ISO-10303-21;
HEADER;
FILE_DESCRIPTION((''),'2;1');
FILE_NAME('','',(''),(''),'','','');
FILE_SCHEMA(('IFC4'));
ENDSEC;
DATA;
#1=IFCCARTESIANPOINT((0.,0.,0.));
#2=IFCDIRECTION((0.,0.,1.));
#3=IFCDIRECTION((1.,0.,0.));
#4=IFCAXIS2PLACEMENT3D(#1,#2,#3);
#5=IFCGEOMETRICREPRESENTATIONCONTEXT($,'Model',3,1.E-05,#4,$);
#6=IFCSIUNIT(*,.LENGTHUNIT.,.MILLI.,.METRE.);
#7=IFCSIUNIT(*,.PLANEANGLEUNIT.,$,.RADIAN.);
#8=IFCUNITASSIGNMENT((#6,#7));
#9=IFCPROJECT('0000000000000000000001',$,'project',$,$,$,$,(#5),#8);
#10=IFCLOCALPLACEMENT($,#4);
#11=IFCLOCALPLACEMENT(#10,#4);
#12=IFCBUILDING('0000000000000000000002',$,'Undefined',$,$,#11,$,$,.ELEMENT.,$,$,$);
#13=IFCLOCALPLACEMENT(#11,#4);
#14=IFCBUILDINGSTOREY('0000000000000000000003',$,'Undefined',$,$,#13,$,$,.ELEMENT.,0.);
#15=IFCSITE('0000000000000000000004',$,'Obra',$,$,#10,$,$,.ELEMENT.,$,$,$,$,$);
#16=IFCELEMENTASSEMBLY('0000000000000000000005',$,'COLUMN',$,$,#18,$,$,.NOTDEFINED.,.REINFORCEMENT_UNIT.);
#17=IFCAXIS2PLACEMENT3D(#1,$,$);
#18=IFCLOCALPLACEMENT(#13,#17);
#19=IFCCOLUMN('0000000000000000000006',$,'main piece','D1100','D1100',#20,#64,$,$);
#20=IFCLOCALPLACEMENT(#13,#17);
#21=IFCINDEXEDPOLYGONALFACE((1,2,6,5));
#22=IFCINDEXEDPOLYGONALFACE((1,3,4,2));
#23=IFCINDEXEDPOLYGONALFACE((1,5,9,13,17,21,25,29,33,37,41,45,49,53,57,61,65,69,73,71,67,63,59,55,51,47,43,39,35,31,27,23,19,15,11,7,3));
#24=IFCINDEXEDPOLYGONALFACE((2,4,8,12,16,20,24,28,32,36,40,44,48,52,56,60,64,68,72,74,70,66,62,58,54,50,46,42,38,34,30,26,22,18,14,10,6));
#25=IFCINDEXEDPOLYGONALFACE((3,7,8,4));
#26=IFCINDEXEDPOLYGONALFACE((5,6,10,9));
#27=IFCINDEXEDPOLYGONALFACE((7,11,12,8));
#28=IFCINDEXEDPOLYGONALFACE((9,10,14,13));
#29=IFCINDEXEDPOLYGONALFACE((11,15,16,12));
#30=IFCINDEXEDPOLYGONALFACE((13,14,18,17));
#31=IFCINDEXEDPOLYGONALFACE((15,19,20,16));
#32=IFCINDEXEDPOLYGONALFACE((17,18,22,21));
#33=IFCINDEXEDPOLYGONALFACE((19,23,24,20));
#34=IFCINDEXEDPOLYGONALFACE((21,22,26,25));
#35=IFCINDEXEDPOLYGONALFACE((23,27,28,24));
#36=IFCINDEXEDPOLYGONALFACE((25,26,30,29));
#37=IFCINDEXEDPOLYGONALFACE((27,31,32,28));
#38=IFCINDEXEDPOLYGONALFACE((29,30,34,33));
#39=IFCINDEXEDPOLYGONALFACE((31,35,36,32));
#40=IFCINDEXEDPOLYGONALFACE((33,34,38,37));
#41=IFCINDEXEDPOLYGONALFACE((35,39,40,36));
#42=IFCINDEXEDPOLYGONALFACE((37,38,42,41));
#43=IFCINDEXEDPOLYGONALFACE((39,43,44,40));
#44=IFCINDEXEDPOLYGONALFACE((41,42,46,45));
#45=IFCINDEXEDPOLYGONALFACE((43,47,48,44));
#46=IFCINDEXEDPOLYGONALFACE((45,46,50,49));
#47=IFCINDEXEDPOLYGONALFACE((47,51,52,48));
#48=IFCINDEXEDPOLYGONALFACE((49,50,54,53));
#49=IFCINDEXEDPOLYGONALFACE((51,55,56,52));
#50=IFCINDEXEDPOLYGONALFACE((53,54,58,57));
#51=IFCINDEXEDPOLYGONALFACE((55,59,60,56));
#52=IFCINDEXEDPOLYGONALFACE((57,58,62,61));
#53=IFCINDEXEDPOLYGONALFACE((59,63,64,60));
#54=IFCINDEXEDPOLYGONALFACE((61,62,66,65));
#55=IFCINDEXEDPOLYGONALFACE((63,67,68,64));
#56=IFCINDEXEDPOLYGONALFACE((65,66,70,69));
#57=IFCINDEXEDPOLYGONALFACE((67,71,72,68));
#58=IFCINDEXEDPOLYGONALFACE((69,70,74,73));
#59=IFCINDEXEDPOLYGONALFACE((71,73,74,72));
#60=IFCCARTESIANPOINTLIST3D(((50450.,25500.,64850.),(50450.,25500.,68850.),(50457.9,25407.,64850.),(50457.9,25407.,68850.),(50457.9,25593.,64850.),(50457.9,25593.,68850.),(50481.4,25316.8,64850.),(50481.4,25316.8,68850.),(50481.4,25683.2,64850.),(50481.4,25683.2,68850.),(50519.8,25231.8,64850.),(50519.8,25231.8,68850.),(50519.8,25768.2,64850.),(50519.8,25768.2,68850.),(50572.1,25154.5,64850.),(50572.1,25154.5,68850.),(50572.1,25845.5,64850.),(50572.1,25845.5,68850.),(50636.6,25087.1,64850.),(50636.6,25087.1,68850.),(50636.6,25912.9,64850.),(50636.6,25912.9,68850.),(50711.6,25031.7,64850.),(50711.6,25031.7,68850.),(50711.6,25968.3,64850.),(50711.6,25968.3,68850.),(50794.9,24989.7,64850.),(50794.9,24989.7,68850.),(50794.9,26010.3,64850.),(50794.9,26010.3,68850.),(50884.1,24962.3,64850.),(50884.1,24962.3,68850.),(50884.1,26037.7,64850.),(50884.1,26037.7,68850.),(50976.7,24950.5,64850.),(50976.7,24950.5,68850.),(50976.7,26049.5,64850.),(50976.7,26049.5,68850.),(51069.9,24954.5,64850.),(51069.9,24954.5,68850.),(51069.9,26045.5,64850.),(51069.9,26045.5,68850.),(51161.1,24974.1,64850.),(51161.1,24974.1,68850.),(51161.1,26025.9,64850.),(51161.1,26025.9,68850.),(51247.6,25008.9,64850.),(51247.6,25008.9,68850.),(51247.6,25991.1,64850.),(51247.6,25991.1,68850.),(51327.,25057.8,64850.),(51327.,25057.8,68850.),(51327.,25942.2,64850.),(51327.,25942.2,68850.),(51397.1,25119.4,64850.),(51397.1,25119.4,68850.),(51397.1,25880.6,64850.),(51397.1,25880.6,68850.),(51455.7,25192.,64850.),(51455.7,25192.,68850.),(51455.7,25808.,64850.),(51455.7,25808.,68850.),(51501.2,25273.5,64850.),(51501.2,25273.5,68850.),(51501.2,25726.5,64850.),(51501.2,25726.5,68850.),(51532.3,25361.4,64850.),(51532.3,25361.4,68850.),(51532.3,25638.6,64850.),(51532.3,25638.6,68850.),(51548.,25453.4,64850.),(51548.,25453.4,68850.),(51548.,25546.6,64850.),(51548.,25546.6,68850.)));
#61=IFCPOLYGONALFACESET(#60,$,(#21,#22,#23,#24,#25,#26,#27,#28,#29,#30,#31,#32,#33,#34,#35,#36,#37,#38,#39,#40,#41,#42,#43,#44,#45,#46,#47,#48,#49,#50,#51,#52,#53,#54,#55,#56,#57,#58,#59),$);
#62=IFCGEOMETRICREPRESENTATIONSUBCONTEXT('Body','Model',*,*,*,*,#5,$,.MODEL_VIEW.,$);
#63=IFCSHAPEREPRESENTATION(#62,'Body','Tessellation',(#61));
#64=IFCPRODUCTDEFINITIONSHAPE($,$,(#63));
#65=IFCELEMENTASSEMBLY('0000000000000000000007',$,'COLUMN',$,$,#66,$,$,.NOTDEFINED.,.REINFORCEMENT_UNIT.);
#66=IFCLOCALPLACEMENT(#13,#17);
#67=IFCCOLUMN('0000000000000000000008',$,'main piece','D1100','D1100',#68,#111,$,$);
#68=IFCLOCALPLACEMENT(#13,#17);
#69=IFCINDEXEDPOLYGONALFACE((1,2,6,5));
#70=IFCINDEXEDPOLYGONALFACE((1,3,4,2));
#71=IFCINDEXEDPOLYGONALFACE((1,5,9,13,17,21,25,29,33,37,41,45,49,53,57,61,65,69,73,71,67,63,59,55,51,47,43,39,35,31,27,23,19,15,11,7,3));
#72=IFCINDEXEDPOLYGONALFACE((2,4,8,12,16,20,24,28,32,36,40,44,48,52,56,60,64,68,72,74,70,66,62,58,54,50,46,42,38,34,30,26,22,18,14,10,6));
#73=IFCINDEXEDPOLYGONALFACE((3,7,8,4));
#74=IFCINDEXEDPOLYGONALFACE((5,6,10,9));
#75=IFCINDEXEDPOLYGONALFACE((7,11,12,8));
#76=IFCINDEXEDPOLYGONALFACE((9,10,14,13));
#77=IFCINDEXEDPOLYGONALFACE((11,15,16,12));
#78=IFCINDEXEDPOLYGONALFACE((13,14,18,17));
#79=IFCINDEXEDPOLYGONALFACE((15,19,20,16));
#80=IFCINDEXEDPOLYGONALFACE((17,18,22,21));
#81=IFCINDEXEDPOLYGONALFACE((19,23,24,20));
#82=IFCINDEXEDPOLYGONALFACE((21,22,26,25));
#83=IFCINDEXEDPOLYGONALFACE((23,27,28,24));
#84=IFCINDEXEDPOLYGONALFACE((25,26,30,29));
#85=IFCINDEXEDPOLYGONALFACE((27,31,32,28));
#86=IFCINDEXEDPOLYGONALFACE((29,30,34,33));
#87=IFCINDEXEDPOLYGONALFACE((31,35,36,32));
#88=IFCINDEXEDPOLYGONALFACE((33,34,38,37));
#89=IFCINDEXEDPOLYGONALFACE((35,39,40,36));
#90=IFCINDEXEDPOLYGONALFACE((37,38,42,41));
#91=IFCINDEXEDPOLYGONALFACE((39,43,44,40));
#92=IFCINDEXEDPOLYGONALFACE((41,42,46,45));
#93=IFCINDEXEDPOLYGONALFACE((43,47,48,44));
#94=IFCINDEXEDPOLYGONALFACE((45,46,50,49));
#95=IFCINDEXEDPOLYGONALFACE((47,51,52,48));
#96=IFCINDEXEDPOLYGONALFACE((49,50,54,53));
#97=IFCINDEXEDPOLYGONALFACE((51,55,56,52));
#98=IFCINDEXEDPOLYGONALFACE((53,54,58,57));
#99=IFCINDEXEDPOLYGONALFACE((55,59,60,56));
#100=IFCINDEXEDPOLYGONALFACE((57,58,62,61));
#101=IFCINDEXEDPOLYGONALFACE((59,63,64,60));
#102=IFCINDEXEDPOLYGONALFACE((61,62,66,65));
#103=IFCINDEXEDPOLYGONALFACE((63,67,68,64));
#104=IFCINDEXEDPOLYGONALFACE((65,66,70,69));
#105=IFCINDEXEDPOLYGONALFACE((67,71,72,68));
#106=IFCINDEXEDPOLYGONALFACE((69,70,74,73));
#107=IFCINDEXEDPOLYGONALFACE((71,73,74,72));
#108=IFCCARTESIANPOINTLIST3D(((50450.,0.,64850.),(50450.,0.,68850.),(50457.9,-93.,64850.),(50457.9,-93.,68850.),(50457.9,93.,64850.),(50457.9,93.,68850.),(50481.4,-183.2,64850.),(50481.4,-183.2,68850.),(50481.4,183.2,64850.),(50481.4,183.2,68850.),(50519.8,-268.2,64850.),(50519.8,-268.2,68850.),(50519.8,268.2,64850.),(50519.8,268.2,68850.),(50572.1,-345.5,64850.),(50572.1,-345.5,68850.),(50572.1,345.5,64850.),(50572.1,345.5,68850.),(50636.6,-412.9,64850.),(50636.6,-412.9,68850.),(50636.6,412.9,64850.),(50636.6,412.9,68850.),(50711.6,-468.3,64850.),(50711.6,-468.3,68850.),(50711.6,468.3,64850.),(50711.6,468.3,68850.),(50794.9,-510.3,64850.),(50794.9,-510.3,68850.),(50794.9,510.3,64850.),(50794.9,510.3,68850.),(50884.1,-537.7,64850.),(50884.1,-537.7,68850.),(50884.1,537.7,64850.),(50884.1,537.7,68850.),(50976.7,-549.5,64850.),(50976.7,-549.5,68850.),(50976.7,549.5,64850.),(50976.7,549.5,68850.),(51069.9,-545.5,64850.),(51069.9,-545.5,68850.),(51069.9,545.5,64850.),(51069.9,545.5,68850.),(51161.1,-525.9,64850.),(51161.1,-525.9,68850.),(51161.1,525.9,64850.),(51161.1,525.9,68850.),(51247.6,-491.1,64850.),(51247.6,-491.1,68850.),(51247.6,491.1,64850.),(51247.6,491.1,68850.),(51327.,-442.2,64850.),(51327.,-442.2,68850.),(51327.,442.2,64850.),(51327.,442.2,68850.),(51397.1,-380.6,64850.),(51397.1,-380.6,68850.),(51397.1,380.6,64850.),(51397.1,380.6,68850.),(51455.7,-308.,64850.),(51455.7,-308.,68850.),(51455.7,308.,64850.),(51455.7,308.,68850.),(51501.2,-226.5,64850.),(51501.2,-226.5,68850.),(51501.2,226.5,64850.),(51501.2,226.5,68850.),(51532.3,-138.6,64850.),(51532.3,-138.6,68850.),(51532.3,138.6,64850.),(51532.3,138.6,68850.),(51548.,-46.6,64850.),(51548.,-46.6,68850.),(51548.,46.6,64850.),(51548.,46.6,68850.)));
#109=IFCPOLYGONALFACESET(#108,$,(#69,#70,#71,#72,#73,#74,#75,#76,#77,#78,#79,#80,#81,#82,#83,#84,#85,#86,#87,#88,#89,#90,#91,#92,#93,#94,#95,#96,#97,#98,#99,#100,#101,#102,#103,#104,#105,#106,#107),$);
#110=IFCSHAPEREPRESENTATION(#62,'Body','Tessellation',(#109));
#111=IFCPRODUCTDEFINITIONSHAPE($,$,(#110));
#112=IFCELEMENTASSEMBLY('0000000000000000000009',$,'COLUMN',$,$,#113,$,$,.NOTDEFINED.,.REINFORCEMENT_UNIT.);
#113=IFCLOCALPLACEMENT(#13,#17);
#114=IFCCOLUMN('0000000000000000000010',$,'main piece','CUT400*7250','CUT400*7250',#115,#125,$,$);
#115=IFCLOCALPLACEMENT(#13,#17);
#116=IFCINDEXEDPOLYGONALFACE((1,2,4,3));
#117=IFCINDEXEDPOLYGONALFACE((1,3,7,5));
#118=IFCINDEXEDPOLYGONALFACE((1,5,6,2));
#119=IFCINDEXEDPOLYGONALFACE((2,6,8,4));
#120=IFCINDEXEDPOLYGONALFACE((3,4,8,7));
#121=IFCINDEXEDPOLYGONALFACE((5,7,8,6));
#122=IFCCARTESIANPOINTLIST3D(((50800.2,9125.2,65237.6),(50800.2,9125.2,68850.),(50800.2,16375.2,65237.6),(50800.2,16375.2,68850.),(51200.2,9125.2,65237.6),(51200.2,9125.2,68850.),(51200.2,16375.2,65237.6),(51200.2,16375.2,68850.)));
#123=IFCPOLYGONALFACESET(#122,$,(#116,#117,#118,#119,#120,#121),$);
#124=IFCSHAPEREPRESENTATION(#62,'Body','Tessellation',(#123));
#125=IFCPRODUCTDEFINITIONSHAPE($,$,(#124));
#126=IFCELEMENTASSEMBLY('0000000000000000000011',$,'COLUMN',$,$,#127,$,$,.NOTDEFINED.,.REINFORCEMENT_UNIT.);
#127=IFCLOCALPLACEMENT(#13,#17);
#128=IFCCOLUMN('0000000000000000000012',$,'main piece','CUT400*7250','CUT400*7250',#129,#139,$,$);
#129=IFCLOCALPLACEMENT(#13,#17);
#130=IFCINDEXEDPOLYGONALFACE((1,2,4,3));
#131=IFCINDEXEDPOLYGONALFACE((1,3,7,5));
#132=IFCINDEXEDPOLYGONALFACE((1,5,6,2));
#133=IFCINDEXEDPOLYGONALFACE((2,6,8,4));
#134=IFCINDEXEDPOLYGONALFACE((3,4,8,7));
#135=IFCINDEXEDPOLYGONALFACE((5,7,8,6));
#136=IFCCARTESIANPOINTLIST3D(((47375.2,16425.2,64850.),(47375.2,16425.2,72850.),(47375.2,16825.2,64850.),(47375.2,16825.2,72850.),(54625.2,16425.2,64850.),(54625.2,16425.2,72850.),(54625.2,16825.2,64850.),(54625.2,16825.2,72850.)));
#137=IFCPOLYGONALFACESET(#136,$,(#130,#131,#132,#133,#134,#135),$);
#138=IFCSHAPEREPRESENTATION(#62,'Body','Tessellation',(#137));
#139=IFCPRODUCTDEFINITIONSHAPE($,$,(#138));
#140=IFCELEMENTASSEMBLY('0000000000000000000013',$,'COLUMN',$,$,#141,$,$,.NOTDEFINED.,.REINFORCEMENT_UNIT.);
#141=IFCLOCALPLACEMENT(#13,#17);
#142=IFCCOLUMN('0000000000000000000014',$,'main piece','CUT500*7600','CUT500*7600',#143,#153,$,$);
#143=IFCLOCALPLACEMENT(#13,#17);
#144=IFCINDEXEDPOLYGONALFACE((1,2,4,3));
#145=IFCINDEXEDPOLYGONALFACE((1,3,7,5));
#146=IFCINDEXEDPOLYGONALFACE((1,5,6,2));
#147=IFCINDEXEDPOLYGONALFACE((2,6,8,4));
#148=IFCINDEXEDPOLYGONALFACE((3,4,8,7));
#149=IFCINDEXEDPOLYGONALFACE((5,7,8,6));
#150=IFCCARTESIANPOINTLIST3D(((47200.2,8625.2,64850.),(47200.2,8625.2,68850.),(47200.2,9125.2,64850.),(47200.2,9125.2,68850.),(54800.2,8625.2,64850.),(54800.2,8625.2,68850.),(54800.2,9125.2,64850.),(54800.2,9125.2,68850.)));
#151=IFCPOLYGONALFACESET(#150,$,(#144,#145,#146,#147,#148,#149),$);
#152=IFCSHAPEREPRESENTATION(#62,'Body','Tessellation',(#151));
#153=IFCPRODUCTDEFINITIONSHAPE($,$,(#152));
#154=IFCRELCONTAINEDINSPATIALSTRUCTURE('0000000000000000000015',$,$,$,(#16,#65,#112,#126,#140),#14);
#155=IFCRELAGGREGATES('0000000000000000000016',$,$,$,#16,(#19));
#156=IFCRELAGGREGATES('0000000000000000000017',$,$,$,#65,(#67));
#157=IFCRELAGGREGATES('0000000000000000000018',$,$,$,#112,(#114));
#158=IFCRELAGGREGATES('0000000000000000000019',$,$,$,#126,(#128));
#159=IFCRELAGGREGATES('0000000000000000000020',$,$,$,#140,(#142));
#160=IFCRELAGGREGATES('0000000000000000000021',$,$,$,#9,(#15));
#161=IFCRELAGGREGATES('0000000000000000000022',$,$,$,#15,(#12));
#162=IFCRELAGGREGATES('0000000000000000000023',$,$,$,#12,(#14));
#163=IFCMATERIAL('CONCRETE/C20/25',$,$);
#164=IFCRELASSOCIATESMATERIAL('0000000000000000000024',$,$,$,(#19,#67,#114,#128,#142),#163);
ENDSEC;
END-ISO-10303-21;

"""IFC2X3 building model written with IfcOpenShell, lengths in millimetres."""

from ifc_helpers import new_model, si_unit, frame, origin_with_axes, origin_2d_with_axis, place, context, subcontext, project, spatial, rectangle, circle, extrude, material, element, aggregate, save


model = new_model("IFC2X3")

# Units and contexts
model_context = context("Model", 3, precision=1e-05, world=origin_with_axes())
body_context = subcontext(model_context, "Body", "Model", "MODEL_VIEW")
ifc_project = project(units=[si_unit("LENGTHUNIT", "METRE", prefix="MILLI"), si_unit("PLANEANGLEUNIT", "RADIAN")], contexts=[model_context])

# Site, building, storey
site_placement = place(None, origin_with_axes())
site = spatial("IfcSite", under=ifc_project, at=site_placement, Name="Obra", CompositionType="ELEMENT")
building_placement = place(site_placement, origin_with_axes())
building = spatial("IfcBuilding", under=site, at=building_placement, Name="Undefined", CompositionType="ELEMENT")
storey_placement = place(building_placement, origin_with_axes())
storey = spatial("IfcBuildingStorey", under=building, at=storey_placement, Name="Undefined", CompositionType="ELEMENT", Elevation=0.0)

# Element assemblies, columns
assembly_1_placement = place(storey_placement, origin_with_axes())
assembly_1 = element("IfcElementAssembly", 1, at=assembly_1_placement, inside=storey, Name="COLUMN", AssemblyPlace="NOTDEFINED", PredefinedType="REINFORCEMENT_UNIT")
ifc_material_1 = material(Name="CONCRETE/C20/25")
column_1_placement = place(assembly_1_placement, frame((51000.0, 25500.0, 64850.0), z_axis=(0.0, 0.0, 1.0), x_axis=(0.0, 1.0, 0.0)))
column_1 = element("IfcColumn", 2, at=column_1_placement, material=ifc_material_1, Name="main piece", Description="D1100", ObjectType="D1100", context=body_context, shape_type="SweptSolid", body=[
    extrude(circle(Radius=550.0, at=origin_2d_with_axis()), frame((0.0, 0.0, 4000.0), z_axis=(0.0, 0.0, -1.0), x_axis=(0.0, 1.0, 0.0)), (0.0, 0.0, 1.0), 4000.0),
])
aggregate(assembly_1, [column_1])
assembly_2_placement = place(storey_placement, origin_with_axes())
assembly_2 = element("IfcElementAssembly", 3, at=assembly_2_placement, inside=storey, Name="COLUMN", AssemblyPlace="NOTDEFINED", PredefinedType="REINFORCEMENT_UNIT")
column_2_placement = place(assembly_2_placement, frame((51000.0, 0.0, 64850.0), z_axis=(0.0, 0.0, 1.0), x_axis=(0.0, 1.0, 0.0)))
column_2 = element("IfcColumn", 4, at=column_2_placement, material=ifc_material_1, Name="main piece", Description="D1100", ObjectType="D1100", context=body_context, shape_type="SweptSolid", body=[
    extrude(circle(Radius=550.0, at=origin_2d_with_axis()), frame((0.0, 0.0, 4000.0), z_axis=(0.0, 0.0, -1.0), x_axis=(0.0, 1.0, 0.0)), (0.0, 0.0, 1.0), 4000.0),
])
aggregate(assembly_2, [column_2])
assembly_3_placement = place(storey_placement, origin_with_axes())
assembly_3 = element("IfcElementAssembly", 5, at=assembly_3_placement, inside=storey, Name="COLUMN", AssemblyPlace="NOTDEFINED", PredefinedType="REINFORCEMENT_UNIT")
column_3_placement = place(assembly_3_placement, frame((51000.2, 12750.2, 65237.6), z_axis=(0.0, 0.0, 1.0), x_axis=(0.0, -1.0, 0.0)))
column_3 = element("IfcColumn", 6, at=column_3_placement, material=ifc_material_1, Name="main piece", Description="CUT400*7250", ObjectType="CUT400*7250", context=body_context, shape_type="SweptSolid", body=[
    extrude(rectangle(XDim=400.0, YDim=7250.0, at=origin_2d_with_axis()), frame((0.0, 0.0, 3612.4), z_axis=(0.0, 0.0, -1.0), x_axis=(0.0, 1.0, 0.0)), (0.0, 0.0, 1.0), 3612.4),
])
aggregate(assembly_3, [column_3])
assembly_4_placement = place(storey_placement, origin_with_axes())
assembly_4 = element("IfcElementAssembly", 7, at=assembly_4_placement, inside=storey, Name="COLUMN", AssemblyPlace="NOTDEFINED", PredefinedType="REINFORCEMENT_UNIT")
column_4_placement = place(assembly_4_placement, frame((51000.2, 16625.2, 64850.0), z_axis=(0.0, 0.0, 1.0), x_axis=(-1.0, 0.0, 0.0)))
column_4 = element("IfcColumn", 8, at=column_4_placement, material=ifc_material_1, Name="main piece", Description="CUT400*7250", ObjectType="CUT400*7250", context=body_context, shape_type="SweptSolid", body=[
    extrude(rectangle(XDim=400.0, YDim=7250.0, at=origin_2d_with_axis()), frame((0.0, 0.0, 8000.0), z_axis=(0.0, 0.0, -1.0), x_axis=(0.0, 1.0, 0.0)), (0.0, 0.0, 1.0), 8000.0),
])
aggregate(assembly_4, [column_4])
assembly_5_placement = place(storey_placement, origin_with_axes())
assembly_5 = element("IfcElementAssembly", 9, at=assembly_5_placement, inside=storey, Name="COLUMN", AssemblyPlace="NOTDEFINED", PredefinedType="REINFORCEMENT_UNIT")
column_5_placement = place(assembly_5_placement, frame((51000.2, 8875.2, 64850.0), z_axis=(0.0, 0.0, 1.0), x_axis=(-1.0, 0.0, 0.0)))
column_5 = element("IfcColumn", 10, at=column_5_placement, material=ifc_material_1, Name="main piece", Description="CUT500*7600", ObjectType="CUT500*7600", context=body_context, shape_type="SweptSolid", body=[
    extrude(rectangle(XDim=500.0, YDim=7600.0, at=origin_2d_with_axis()), frame((0.0, 0.0, 4000.0), z_axis=(0.0, 0.0, -1.0), x_axis=(0.0, 1.0, 0.0)), (0.0, 0.0, 1.0), 4000.0),
])
aggregate(assembly_5, [column_5])

save(model, "model.ifc")
